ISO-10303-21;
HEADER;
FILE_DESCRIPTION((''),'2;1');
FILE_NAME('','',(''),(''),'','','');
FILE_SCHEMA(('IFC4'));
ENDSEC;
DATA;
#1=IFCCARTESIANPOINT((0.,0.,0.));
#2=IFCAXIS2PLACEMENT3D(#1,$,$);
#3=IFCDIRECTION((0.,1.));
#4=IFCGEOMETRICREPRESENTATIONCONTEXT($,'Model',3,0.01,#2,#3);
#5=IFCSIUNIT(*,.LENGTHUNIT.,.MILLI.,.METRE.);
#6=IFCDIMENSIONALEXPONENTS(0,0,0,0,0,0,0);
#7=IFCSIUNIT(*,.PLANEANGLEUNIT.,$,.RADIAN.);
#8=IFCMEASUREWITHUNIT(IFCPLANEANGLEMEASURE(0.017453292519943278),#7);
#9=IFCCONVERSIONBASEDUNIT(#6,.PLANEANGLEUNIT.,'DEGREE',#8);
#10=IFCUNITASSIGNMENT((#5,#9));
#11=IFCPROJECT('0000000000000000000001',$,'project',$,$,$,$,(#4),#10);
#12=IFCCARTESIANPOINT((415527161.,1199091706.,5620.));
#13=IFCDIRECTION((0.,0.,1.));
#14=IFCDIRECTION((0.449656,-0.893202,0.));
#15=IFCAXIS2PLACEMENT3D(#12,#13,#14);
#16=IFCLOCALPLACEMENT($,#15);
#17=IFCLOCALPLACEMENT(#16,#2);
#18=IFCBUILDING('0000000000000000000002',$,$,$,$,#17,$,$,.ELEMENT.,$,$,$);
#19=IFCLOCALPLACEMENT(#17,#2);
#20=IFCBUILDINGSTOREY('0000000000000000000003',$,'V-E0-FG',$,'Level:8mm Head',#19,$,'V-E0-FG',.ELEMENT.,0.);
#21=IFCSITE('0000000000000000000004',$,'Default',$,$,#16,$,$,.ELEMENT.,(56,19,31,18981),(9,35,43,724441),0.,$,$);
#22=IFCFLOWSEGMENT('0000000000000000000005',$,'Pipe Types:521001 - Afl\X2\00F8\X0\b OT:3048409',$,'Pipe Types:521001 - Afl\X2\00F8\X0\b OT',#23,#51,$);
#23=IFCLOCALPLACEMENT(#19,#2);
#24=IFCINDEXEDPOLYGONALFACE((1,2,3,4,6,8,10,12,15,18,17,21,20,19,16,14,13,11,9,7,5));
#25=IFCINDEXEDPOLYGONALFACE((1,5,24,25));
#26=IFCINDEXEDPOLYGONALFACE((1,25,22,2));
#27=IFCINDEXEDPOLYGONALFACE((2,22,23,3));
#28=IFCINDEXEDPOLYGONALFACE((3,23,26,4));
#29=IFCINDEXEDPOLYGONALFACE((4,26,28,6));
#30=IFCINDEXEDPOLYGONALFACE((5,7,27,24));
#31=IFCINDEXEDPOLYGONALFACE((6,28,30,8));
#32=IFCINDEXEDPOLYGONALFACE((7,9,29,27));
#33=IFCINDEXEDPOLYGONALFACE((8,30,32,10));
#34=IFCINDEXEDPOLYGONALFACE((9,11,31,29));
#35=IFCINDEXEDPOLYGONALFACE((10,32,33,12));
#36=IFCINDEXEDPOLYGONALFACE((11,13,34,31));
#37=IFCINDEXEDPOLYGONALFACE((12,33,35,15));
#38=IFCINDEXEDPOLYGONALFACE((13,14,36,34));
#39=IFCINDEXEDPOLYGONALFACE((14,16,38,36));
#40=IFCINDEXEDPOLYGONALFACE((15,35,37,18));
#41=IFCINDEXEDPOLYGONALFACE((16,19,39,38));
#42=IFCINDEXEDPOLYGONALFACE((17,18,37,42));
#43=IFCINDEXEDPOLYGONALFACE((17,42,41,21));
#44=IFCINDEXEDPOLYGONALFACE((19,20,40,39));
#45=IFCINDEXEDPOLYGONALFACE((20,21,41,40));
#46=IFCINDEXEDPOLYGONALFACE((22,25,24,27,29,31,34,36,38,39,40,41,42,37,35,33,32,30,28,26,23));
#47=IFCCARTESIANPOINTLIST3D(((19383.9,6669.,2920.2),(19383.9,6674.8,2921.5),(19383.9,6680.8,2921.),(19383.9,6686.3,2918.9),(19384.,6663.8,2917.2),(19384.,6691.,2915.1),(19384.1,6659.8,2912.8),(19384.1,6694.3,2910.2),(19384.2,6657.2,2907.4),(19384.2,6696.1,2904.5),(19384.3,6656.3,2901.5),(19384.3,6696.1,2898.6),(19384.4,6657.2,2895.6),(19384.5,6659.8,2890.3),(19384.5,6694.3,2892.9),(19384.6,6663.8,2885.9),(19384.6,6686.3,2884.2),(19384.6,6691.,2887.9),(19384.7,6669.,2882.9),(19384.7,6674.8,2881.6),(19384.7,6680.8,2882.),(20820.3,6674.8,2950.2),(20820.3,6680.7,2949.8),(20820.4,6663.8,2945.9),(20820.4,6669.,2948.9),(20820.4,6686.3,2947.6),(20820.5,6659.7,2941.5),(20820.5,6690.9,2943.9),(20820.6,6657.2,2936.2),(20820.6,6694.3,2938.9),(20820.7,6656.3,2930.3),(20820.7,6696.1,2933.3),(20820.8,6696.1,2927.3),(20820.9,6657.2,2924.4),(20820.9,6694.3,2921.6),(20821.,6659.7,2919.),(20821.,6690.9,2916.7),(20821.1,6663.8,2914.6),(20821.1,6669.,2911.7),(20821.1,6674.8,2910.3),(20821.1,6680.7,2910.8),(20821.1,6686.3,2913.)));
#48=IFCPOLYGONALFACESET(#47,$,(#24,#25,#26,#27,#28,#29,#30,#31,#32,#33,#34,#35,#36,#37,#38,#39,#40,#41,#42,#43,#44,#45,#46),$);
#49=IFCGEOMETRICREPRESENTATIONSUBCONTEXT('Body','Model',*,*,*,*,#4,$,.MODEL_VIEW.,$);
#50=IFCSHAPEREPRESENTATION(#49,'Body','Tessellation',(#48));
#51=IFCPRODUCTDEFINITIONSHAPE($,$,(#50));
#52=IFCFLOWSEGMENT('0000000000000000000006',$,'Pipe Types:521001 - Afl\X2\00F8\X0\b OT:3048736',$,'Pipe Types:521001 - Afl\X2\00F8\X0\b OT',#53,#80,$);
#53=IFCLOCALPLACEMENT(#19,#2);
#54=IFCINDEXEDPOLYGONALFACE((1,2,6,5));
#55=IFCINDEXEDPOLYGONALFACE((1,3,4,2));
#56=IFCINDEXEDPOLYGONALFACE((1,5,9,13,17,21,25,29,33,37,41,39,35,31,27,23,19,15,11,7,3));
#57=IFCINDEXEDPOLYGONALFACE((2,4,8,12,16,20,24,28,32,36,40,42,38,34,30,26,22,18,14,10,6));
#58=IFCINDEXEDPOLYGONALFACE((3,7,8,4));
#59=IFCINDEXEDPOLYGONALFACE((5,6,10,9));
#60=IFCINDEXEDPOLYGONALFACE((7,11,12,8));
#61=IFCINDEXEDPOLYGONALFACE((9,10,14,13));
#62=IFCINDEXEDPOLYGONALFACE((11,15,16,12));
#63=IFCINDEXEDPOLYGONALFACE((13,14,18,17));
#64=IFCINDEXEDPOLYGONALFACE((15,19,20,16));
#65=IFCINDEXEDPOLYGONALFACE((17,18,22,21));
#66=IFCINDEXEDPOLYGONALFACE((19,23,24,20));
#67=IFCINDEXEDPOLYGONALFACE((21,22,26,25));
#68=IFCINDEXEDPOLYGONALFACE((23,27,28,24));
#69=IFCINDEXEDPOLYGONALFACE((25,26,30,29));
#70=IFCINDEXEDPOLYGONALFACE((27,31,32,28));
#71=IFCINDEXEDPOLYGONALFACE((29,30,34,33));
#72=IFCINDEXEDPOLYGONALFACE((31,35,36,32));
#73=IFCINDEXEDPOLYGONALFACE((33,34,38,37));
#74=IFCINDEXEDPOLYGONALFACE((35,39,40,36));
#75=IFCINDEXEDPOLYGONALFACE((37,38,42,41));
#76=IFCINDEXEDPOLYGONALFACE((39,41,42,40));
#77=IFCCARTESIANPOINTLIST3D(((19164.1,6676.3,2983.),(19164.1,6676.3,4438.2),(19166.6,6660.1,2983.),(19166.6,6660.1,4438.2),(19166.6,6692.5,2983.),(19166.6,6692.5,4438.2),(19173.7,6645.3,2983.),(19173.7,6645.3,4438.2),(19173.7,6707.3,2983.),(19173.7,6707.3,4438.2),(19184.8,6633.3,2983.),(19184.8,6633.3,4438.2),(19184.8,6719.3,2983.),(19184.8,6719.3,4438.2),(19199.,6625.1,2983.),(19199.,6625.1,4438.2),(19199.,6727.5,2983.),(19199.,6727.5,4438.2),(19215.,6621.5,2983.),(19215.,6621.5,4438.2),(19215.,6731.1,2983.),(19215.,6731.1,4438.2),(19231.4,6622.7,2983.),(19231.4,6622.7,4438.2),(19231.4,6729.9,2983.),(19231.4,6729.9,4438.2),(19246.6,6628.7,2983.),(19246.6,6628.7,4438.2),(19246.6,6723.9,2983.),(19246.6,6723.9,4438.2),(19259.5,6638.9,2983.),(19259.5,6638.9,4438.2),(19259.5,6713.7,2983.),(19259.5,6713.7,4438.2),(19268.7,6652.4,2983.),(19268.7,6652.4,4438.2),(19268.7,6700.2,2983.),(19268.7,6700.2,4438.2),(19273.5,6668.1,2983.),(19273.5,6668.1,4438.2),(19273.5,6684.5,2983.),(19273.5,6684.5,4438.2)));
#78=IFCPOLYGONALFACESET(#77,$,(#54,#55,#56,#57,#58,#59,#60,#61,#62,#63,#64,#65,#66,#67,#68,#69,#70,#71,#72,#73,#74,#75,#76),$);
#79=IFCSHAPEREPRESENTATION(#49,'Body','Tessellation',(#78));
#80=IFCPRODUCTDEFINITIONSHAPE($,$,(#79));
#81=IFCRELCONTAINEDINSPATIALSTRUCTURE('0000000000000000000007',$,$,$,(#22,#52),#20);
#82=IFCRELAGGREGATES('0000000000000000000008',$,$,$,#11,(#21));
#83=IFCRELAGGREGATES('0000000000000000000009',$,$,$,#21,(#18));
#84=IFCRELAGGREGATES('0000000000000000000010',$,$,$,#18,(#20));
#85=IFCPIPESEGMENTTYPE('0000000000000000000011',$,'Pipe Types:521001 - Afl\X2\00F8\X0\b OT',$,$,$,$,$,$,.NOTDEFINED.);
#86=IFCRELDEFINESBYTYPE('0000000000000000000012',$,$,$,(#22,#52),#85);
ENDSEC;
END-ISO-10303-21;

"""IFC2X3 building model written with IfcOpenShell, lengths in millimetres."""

from ifc_helpers import new_model, entity, si_unit, converted_unit, direction, frame, frame_2d, origin, origin_2d_with_axis, place, context, subcontext, project, spatial, circle, extrude, type_object, element, save


model = new_model("IFC2X3")

# Units and contexts
model_context = context("Model", 3, precision=0.01, world=origin(), true_north=direction((0.0, 1.0)))
body_context = subcontext(model_context, "Body", "Model", "MODEL_VIEW")
ifc_project = project(units=[si_unit("LENGTHUNIT", "METRE", prefix="MILLI"), converted_unit("PLANEANGLEUNIT", "DEGREE", entity("IfcPlaneAngleMeasure", 0.017453292519943278), si_unit("PLANEANGLEUNIT", "RADIAN"), dimensions=[0, 0, 0, 0, 0, 0, 0])], contexts=[model_context])

# Site, building, storey
site_placement = place(None, frame((415527161.0, 1199091706.0, 5620.0), z_axis=(0.0, 0.0, 1.0), x_axis=(0.449656, -0.893202, 0.0)))
site = spatial("IfcSite", under=ifc_project, at=site_placement, Name="Default", CompositionType="ELEMENT", RefLatitude=(56, 19, 31, 18981), RefLongitude=(9, 35, 43, 724441), RefElevation=0.0)
building_placement = place(site_placement, origin())
building = spatial("IfcBuilding", under=site, at=building_placement, CompositionType="ELEMENT")
storey_placement = place(building_placement, origin())
storey = spatial("IfcBuildingStorey", under=building, at=storey_placement, Name="V-E0-FG", ObjectType="Level:8mm Head", LongName="V-E0-FG", CompositionType="ELEMENT", Elevation=0.0)

# Flow segments
pipe_segment_type_1 = type_object("IfcPipeSegmentType", Name="Pipe Types:521001 - Afløb OT", PredefinedType="NOTDEFINED")
flow_segment_1_placement = place(storey_placement, origin())
element("IfcFlowSegment", 1, at=flow_segment_1_placement, inside=storey, type_object=pipe_segment_type_1, Name="Pipe Types:521001 - Afløb OT:3048409", ObjectType="Pipe Types:521001 - Afløb OT", context=body_context, shape_type="SweptSolid", body=[
    extrude(circle(Radius=20.0, at=frame_2d((0.0, 0.0), x_axis=(1.0, 0.0))), frame((19384.3, 6676.3, 2901.5), z_axis=(0.9998, -0.000019, 0.019996), x_axis=(-0.000019, -1.0, 0.0)), (0.0, 0.0, 1.0), 1436.7),
])
flow_segment_2_placement = place(storey_placement, origin())
element("IfcFlowSegment", 2, at=flow_segment_2_placement, inside=storey, type_object=pipe_segment_type_1, Name="Pipe Types:521001 - Afløb OT:3048736", ObjectType="Pipe Types:521001 - Afløb OT", context=body_context, shape_type="SweptSolid", body=[
    extrude(circle(Radius=55.0, at=origin_2d_with_axis()), frame((19219.1, 6676.3, 2983.0), z_axis=(0.0, 0.0, 1.0), x_axis=(-1.0, 0.0, 0.0)), (0.0, 0.0, 1.0), 1455.2),
])

save(model, "model.ifc")
